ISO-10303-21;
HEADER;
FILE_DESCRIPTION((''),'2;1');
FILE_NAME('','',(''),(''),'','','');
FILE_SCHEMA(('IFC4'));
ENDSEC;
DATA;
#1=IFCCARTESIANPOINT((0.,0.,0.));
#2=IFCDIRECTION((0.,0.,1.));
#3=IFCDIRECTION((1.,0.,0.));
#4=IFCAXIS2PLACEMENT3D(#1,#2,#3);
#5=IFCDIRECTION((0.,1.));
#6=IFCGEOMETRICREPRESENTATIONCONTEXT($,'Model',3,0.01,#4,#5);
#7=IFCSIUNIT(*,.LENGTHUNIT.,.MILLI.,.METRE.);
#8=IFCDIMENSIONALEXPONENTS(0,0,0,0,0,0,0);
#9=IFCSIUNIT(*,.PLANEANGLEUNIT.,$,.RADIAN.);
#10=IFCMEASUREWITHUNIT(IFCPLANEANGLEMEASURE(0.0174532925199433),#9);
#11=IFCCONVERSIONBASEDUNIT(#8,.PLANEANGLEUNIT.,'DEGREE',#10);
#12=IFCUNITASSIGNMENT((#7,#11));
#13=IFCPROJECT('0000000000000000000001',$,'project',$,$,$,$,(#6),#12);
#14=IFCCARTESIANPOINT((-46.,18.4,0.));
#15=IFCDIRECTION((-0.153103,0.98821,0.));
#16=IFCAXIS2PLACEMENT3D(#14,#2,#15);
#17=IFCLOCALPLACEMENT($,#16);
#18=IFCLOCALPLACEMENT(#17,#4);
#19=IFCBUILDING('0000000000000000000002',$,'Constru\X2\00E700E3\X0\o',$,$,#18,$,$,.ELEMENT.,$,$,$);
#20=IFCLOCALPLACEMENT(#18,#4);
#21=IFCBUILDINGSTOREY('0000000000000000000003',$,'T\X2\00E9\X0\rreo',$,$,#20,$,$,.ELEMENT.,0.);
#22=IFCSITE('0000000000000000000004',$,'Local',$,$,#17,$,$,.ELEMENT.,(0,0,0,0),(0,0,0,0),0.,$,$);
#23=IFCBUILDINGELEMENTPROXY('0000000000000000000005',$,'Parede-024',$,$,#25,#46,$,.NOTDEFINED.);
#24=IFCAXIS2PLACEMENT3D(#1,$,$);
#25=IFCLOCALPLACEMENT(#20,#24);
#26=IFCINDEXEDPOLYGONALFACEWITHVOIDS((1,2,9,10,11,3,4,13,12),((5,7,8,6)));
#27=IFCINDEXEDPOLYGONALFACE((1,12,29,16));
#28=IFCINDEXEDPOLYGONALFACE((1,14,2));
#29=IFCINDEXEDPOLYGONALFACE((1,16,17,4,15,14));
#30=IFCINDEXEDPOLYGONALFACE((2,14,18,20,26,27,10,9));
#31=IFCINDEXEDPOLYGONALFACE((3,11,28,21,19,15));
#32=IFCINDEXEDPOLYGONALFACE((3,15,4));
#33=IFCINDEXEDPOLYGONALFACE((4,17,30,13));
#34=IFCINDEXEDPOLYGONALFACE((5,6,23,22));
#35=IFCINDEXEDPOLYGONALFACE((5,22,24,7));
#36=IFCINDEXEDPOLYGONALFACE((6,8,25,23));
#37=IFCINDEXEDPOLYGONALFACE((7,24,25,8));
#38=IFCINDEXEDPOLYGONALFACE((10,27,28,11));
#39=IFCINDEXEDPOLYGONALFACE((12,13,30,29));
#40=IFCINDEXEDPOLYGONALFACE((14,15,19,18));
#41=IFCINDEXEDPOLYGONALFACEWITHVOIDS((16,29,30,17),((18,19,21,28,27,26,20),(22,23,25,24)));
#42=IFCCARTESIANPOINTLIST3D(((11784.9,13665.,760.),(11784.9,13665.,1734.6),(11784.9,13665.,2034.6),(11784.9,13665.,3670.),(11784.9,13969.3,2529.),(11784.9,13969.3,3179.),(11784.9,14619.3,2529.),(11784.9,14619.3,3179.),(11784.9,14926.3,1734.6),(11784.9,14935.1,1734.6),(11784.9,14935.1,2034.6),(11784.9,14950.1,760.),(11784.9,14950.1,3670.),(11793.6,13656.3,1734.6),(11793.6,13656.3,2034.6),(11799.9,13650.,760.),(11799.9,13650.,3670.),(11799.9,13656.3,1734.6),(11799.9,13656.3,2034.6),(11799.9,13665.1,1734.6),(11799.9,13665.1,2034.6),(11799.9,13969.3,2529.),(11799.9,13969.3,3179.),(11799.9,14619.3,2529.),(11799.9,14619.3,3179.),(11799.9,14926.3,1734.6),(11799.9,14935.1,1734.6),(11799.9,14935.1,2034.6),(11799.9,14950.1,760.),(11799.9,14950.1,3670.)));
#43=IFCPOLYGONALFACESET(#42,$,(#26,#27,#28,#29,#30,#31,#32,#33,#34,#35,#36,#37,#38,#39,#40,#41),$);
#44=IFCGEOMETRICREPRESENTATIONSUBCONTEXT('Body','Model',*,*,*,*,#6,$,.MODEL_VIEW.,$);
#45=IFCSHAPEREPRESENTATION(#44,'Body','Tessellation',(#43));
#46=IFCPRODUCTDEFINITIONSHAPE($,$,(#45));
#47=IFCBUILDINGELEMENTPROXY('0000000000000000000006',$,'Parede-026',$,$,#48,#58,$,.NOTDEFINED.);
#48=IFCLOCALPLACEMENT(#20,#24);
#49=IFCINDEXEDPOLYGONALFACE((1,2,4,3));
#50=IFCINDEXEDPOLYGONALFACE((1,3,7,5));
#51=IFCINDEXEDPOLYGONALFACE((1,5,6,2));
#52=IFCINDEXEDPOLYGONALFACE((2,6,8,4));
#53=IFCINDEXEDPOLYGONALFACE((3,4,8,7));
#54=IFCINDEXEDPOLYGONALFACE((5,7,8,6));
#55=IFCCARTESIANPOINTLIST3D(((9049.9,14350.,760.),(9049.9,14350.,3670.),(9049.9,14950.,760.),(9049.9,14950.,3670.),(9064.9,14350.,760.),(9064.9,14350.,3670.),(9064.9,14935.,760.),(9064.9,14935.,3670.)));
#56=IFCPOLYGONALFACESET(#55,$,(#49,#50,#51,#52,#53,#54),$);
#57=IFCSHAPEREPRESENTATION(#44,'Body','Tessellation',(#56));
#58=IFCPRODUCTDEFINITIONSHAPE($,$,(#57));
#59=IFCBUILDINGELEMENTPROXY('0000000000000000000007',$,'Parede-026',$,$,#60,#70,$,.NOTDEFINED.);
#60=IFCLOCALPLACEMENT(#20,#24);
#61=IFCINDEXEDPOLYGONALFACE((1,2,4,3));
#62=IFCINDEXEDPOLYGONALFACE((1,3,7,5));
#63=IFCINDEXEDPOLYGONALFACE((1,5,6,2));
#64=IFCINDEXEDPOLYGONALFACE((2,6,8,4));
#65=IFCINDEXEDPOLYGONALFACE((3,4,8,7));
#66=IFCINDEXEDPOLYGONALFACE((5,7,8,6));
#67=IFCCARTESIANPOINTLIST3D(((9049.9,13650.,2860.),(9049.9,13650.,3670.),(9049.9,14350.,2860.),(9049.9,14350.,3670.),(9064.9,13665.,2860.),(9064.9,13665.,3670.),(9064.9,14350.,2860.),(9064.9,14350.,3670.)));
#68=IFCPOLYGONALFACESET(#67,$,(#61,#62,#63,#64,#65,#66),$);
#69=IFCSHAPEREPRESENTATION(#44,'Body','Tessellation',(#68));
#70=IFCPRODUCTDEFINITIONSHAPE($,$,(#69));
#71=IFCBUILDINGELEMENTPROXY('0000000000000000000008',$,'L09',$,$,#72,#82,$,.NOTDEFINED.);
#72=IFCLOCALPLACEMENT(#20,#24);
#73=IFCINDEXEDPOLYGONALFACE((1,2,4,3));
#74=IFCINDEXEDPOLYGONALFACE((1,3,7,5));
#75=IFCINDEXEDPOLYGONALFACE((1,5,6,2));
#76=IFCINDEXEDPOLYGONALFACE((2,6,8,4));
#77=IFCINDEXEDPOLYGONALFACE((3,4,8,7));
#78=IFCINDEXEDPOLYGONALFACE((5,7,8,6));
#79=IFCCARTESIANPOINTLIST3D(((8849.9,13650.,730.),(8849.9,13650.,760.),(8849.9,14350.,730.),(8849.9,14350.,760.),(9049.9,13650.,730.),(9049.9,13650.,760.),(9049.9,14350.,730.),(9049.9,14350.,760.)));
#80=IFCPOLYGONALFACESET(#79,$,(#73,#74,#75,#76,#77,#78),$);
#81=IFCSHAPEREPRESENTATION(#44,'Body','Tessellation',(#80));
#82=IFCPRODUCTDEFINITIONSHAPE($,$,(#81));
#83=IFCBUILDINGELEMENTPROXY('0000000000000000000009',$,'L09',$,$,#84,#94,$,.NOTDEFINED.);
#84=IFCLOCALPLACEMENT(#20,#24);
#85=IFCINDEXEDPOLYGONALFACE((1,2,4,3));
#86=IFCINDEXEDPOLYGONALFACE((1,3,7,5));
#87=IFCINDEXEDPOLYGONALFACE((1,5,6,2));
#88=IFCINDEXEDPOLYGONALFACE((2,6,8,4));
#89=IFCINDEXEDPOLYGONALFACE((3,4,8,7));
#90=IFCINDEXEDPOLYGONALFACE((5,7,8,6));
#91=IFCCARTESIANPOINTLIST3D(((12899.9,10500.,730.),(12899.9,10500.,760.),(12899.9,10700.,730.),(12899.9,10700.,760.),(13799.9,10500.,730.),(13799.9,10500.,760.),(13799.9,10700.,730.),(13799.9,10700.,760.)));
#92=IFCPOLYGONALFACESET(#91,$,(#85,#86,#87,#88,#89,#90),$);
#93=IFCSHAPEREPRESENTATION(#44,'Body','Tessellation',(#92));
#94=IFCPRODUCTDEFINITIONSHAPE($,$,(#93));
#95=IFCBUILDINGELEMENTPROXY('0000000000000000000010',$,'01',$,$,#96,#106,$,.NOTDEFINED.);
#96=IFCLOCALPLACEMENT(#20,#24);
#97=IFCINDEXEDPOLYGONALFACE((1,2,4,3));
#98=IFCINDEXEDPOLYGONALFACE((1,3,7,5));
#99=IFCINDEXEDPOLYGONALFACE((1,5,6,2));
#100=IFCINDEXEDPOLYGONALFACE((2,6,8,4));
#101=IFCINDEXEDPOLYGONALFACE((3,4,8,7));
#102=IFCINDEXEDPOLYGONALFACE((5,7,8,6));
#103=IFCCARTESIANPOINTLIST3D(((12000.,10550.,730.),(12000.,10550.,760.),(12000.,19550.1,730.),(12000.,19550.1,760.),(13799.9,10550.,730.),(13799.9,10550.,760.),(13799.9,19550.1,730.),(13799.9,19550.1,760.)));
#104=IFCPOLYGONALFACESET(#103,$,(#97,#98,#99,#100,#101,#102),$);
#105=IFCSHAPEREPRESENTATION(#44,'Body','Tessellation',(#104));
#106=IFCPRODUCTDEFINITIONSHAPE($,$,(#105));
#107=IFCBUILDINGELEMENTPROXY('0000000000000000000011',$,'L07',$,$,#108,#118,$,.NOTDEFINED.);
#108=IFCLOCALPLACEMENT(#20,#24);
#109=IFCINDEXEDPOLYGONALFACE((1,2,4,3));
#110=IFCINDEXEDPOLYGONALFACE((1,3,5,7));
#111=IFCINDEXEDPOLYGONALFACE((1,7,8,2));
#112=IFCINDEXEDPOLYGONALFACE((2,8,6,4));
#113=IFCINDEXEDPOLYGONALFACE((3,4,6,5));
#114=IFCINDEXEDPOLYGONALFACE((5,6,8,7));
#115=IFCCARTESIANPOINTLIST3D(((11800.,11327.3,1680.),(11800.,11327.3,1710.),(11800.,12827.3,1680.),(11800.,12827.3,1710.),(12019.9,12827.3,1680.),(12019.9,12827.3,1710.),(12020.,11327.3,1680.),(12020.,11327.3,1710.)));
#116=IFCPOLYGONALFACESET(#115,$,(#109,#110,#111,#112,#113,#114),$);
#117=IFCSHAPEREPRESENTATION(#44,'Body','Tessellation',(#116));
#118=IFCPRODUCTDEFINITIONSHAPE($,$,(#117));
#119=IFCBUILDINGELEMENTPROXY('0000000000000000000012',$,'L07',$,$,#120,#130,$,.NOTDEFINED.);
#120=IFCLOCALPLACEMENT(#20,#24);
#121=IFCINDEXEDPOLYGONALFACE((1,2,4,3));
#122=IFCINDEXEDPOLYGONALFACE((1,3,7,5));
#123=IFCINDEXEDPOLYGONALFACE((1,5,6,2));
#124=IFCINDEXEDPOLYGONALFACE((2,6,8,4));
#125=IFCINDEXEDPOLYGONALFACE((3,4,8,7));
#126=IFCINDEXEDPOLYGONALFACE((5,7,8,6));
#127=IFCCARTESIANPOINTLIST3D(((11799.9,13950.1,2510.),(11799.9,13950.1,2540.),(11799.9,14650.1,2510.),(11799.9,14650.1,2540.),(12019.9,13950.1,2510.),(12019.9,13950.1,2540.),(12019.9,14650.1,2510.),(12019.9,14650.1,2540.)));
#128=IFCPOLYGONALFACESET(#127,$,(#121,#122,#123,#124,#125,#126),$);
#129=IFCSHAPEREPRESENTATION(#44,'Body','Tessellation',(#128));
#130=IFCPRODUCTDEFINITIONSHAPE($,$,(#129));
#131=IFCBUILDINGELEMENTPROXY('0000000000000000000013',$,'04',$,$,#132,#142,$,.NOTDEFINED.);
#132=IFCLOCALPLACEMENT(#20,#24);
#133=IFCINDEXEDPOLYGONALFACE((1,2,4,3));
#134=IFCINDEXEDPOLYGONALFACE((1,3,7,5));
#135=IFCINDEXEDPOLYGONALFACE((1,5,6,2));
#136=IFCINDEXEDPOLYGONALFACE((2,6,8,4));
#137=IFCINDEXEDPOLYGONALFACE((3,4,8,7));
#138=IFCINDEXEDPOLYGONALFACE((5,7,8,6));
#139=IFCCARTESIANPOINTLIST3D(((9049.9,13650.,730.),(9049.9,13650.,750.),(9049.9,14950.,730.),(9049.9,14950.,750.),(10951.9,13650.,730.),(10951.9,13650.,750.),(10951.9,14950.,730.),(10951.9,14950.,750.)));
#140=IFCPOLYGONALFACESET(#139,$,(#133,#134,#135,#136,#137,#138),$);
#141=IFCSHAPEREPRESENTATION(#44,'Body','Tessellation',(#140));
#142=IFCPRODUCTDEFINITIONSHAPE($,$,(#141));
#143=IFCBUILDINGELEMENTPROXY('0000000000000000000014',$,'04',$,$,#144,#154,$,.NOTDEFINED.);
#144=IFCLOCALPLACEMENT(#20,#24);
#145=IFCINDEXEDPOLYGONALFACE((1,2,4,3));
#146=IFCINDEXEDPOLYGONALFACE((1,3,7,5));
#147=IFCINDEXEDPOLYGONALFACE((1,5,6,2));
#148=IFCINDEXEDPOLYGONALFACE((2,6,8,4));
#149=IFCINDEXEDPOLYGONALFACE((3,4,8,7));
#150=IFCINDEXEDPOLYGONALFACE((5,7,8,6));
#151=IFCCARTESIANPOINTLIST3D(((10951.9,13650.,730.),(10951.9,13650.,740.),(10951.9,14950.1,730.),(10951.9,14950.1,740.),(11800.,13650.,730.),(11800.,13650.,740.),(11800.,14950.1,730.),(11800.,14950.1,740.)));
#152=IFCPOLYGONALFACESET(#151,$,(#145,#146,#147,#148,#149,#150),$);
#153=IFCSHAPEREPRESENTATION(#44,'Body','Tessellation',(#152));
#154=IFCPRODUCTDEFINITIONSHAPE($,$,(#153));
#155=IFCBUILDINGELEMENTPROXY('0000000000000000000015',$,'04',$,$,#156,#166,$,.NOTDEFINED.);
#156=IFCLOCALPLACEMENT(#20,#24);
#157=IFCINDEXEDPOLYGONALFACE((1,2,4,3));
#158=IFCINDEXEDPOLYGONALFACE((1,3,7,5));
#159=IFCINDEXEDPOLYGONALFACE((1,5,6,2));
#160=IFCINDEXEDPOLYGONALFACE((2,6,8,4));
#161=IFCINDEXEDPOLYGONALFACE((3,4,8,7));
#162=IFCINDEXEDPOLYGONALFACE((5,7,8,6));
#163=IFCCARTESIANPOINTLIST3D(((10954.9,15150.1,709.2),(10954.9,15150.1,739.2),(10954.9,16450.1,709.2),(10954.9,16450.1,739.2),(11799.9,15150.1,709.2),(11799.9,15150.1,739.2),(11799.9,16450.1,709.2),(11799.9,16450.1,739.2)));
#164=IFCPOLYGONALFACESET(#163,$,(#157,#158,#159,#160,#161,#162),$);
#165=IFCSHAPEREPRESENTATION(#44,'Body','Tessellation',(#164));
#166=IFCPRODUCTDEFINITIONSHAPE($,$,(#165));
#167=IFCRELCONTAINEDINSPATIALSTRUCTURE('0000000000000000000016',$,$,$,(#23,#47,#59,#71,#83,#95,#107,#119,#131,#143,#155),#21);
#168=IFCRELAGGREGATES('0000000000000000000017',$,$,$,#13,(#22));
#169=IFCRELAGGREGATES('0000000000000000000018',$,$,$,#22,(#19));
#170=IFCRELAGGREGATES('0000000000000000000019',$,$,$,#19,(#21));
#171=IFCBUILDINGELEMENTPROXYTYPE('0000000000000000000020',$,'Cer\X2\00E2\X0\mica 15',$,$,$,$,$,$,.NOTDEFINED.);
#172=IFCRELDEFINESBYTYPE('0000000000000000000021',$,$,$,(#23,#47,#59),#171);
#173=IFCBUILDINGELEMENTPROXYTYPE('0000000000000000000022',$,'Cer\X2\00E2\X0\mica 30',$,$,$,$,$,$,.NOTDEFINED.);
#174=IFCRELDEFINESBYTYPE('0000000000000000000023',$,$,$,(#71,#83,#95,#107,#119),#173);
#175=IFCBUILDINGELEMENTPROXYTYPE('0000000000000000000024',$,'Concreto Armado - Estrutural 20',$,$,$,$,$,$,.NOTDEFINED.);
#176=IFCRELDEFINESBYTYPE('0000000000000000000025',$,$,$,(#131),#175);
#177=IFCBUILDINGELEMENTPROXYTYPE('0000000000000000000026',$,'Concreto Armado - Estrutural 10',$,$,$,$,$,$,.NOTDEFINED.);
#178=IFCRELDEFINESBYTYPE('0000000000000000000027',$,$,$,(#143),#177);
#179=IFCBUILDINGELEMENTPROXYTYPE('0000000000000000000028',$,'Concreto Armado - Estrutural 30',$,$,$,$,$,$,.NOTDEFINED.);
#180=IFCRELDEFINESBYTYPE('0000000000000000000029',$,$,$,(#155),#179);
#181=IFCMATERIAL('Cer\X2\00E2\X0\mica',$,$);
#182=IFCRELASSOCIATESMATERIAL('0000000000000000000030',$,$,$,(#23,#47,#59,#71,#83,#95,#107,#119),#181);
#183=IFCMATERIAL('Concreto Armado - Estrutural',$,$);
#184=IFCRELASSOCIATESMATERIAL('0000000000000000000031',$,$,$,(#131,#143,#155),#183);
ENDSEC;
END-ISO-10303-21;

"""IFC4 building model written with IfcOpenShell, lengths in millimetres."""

from ifc_helpers import new_model, entity, si_unit, converted_unit, direction, frame, origin_with_axes, origin_2d_with_axis, place, context, subcontext, project, spatial, line, indexed_curve, rectangle, outline, extrude, material, type_object, element, save


model = new_model("IFC4")

# Units and contexts
model_context = context("Model", 3, precision=0.01, world=origin_with_axes(), true_north=direction((0.0, 1.0)))
body_context = subcontext(model_context, "Body", "Model", "MODEL_VIEW")
ifc_project = project(units=[si_unit("LENGTHUNIT", "METRE", prefix="MILLI"), converted_unit("PLANEANGLEUNIT", "DEGREE", entity("IfcPlaneAngleMeasure", 0.0174532925199433), si_unit("PLANEANGLEUNIT", "RADIAN"), dimensions=[0, 0, 0, 0, 0, 0, 0])], contexts=[model_context])

# Site, building, storey
site_placement = place(None, frame((-46.0, 18.4, 0.0), z_axis=(0.0, 0.0, 1.0), x_axis=(-0.153103, 0.98821, 0.0)))
site = spatial("IfcSite", under=ifc_project, at=site_placement, Name="Local", CompositionType="ELEMENT", RefLatitude=(0, 0, 0, 0), RefLongitude=(0, 0, 0, 0), RefElevation=0.0)
building_placement = place(site_placement, origin_with_axes())
building = spatial("IfcBuilding", under=site, at=building_placement, Name="Construção", CompositionType="ELEMENT")
storey_placement = place(building_placement, origin_with_axes())
storey = spatial("IfcBuildingStorey", under=building, at=storey_placement, Name="Térreo", CompositionType="ELEMENT", Elevation=0.0)

# Shared definitions
ifc_material_1 = material(Name="Concreto Armado - Estrutural")

# Shared definitions
ifc_material_2 = material(Name="Cerâmica")
building_element_proxy_type_1 = type_object("IfcBuildingElementProxyType", Name="Cerâmica 15", PredefinedType="NOTDEFINED")

# Building element proxy, openings
proxy_1_placement = place(storey_placement, frame((11799.9, 13650.0, 760.0), z_axis=(0.0, 0.0, 1.0), x_axis=(0.0, 1.0, 0.0)))
proxy_1 = element("IfcBuildingElementProxy", 1, at=proxy_1_placement, inside=storey, type_object=building_element_proxy_type_1, material=ifc_material_2, Name="Parede-024", PredefinedType="NOTDEFINED", context=body_context, shape_type="SweptSolid", body=[
    extrude(outline(indexed_curve([(0.0, 0.0), (1300.0, 0.0), (1300.0, 15.0), (15.0, 15.0)], segments=[line(1, 2, 3, 4, 1)])), origin_with_axes(), (0.0, 0.0, 1.0), 2910.0),
])
opening_1_placement = place(proxy_1_placement, frame((-13650.0, 11799.9, -760.0), z_axis=(0.0, 0.0, 1.0), x_axis=(0.0, -1.0, 0.0)))
element("IfcOpeningElement", 2, at=opening_1_placement, cuts=proxy_1, PredefinedType="OPENING", context=body_context, shape_type="SweptSolid", body=[
    extrude(rectangle(XDim=650.0, YDim=650.0, at=origin_2d_with_axis()), frame((11814.9, 14294.3, 2854.0), z_axis=(1.0, 0.0, 0.0), x_axis=(0.0, 1.0, 0.0)), (0.0, 0.0, -1.0), 45.0),
])
opening_2_placement = place(proxy_1_placement, frame((-13650.0, 11799.9, -760.0), z_axis=(0.0, 0.0, 1.0), x_axis=(0.0, -1.0, 0.0)))
element("IfcOpeningElement", 3, at=opening_2_placement, cuts=proxy_1, PredefinedType="OPENING", context=body_context, shape_type="SweptSolid", body=[
    extrude(rectangle(XDim=1270.0, YDim=300.0, at=origin_2d_with_axis()), frame((11814.9, 14300.1, 1884.6), z_axis=(1.0, 0.0, 0.0), x_axis=(0.0, 1.0, 0.0)), (0.0, 0.0, -1.0), 45.0),
])
opening_3_placement = place(proxy_1_placement, frame((-13650.0, 11799.9, -760.0), z_axis=(0.0, 0.0, 1.0), x_axis=(0.0, -1.0, 0.0)))
element("IfcOpeningElement", 4, at=opening_3_placement, cuts=proxy_1, PredefinedType="OPENING", context=body_context, shape_type="SweptSolid", body=[
    extrude(outline(indexed_curve([(-639.4, -150.0), (630.6, -150.0), (639.4, 150.0), (-639.4, 150.0)], segments=[line(1, 2, 3, 4, 1)])), frame((11814.9, 14295.7, 1884.6), z_axis=(1.0, 0.0, 0.0), x_axis=(0.0, 1.0, 0.0)), (0.0, 0.0, -1.0), 45.0),
])

# Building element proxies
proxy_2_placement = place(storey_placement, frame((9049.9, 14950.0, 760.0), z_axis=(0.0, 0.0, 1.0), x_axis=(0.000002, -1.0, 0.0)))
element("IfcBuildingElementProxy", 5, at=proxy_2_placement, inside=storey, type_object=building_element_proxy_type_1, material=ifc_material_2, Name="Parede-026", PredefinedType="NOTDEFINED", context=body_context, shape_type="SweptSolid", body=[
    extrude(outline(indexed_curve([(0.0, 0.0), (600.0, 0.0), (600.0, 15.0), (15.0, 15.0)], segments=[line(1, 2, 3, 4, 1)])), origin_with_axes(), (0.0, 0.0, 1.0), 2910.0),
])
proxy_3_placement = place(storey_placement, frame((9049.9, 14350.0, 2860.0), z_axis=(0.0, 0.0, 1.0), x_axis=(0.000002, -1.0, 0.0)))
element("IfcBuildingElementProxy", 6, at=proxy_3_placement, inside=storey, type_object=building_element_proxy_type_1, material=ifc_material_2, Name="Parede-026", PredefinedType="NOTDEFINED", context=body_context, shape_type="SweptSolid", body=[
    extrude(outline(indexed_curve([(0.0, 0.0), (700.0, 0.0), (685.0, 15.0), (0.0, 15.0)], segments=[line(1, 2, 3, 4, 1)])), origin_with_axes(), (0.0, 0.0, 1.0), 810.0),
])
building_element_proxy_type_2 = type_object("IfcBuildingElementProxyType", Name="Cerâmica 30", PredefinedType="NOTDEFINED")
proxy_4_placement = place(storey_placement, frame((8849.9, 13650.0, 760.0), z_axis=(0.0, 0.0, 1.0), x_axis=(1.0, 0.0, 0.0)))
element("IfcBuildingElementProxy", 7, at=proxy_4_placement, inside=storey, type_object=building_element_proxy_type_2, material=ifc_material_2, Name="L09", PredefinedType="NOTDEFINED", context=body_context, shape_type="SweptSolid", body=[
    extrude(outline(indexed_curve([(0.0, 0.0), (200.0, 0.0), (200.0, 700.0), (0.0, 700.0)], segments=[line(1, 2, 3, 4, 1)])), frame((0.0, 0.0, -30.0), z_axis=(0.0, 0.0, 1.0), x_axis=(1.0, 0.0, 0.0)), (0.0, 0.0, 1.0), 30.0),
])
proxy_5_placement = place(storey_placement, frame((12899.9, 10500.0, 760.0), z_axis=(0.0, 0.0, 1.0), x_axis=(1.0, 0.0, 0.0)))
element("IfcBuildingElementProxy", 8, at=proxy_5_placement, inside=storey, type_object=building_element_proxy_type_2, material=ifc_material_2, Name="L09", PredefinedType="NOTDEFINED", context=body_context, shape_type="SweptSolid", body=[
    extrude(outline(indexed_curve([(0.0, 0.0), (900.0, 0.0), (900.0, 200.0), (0.0, 200.0)], segments=[line(1, 2, 3, 4, 1)])), frame((0.0, 0.0, -30.0), z_axis=(0.0, 0.0, 1.0), x_axis=(1.0, 0.0, 0.0)), (0.0, 0.0, 1.0), 30.0),
])
proxy_6_placement = place(storey_placement, frame((12000.0, 10550.0, 760.0), z_axis=(0.0, 0.0, 1.0), x_axis=(1.0, 0.0, 0.0)))
element("IfcBuildingElementProxy", 9, at=proxy_6_placement, inside=storey, type_object=building_element_proxy_type_2, material=ifc_material_2, Name="01", PredefinedType="NOTDEFINED", context=body_context, shape_type="SweptSolid", body=[
    extrude(outline(indexed_curve([(0.0, 0.0), (1799.9, 0.0), (1799.9, 9000.1), (0.0, 9000.1)], segments=[line(1, 2, 3, 4, 1)])), frame((0.0, 0.0, -30.0), z_axis=(0.0, 0.0, 1.0), x_axis=(1.0, 0.0, 0.0)), (0.0, 0.0, 1.0), 30.0),
])
proxy_7_placement = place(storey_placement, frame((11800.0, 11327.3, 1710.0), z_axis=(0.0, 0.0, 1.0), x_axis=(1.0, 0.0, 0.0)))
element("IfcBuildingElementProxy", 10, at=proxy_7_placement, inside=storey, type_object=building_element_proxy_type_2, material=ifc_material_2, Name="L07", PredefinedType="NOTDEFINED", context=body_context, shape_type="SweptSolid", body=[
    extrude(outline(indexed_curve([(0.0, 0.0), (220.0, 0.0), (220.0, 1500.0), (0.0, 1500.0)], segments=[line(1, 2, 3, 4, 1)])), frame((0.0, 0.0, -30.0), z_axis=(0.0, 0.0, 1.0), x_axis=(1.0, 0.0, 0.0)), (0.0, 0.0, 1.0), 30.0),
])
proxy_8_placement = place(storey_placement, frame((11799.9, 13950.1, 2540.0), z_axis=(0.0, 0.0, 1.0), x_axis=(1.0, 0.0, 0.0)))
element("IfcBuildingElementProxy", 11, at=proxy_8_placement, inside=storey, type_object=building_element_proxy_type_2, material=ifc_material_2, Name="L07", PredefinedType="NOTDEFINED", context=body_context, shape_type="SweptSolid", body=[
    extrude(outline(indexed_curve([(0.0, 0.0), (220.0, 0.0), (220.0, 700.0), (0.0, 700.0)], segments=[line(1, 2, 3, 4, 1)])), frame((0.0, 0.0, -30.0), z_axis=(0.0, 0.0, 1.0), x_axis=(1.0, 0.0, 0.0)), (0.0, 0.0, 1.0), 30.0),
])
building_element_proxy_type_3 = type_object("IfcBuildingElementProxyType", Name="Concreto Armado - Estrutural 20", PredefinedType="NOTDEFINED")
proxy_9_placement = place(storey_placement, frame((9049.9, 13650.0, 750.0), z_axis=(0.0, 0.0, 1.0), x_axis=(1.0, 0.0, 0.0)))
element("IfcBuildingElementProxy", 12, at=proxy_9_placement, inside=storey, type_object=building_element_proxy_type_3, material=ifc_material_1, Name="04", PredefinedType="NOTDEFINED", context=body_context, shape_type="SweptSolid", body=[
    extrude(outline(indexed_curve([(0.0, 0.0), (1901.9, 0.0), (1901.9, 1300.0), (0.0, 1300.0)], segments=[line(1, 2, 3, 4, 1)])), frame((0.0, 0.0, -20.0), z_axis=(0.0, 0.0, 1.0), x_axis=(1.0, 0.0, 0.0)), (0.0, 0.0, 1.0), 20.0),
])
building_element_proxy_type_4 = type_object("IfcBuildingElementProxyType", Name="Concreto Armado - Estrutural 10", PredefinedType="NOTDEFINED")
proxy_10_placement = place(storey_placement, frame((10951.9, 13650.0, 740.0), z_axis=(0.0, 0.0, 1.0), x_axis=(1.0, 0.0, 0.0)))
element("IfcBuildingElementProxy", 13, at=proxy_10_placement, inside=storey, type_object=building_element_proxy_type_4, material=ifc_material_1, Name="04", PredefinedType="NOTDEFINED", context=body_context, shape_type="SweptSolid", body=[
    extrude(outline(indexed_curve([(0.0, 0.0), (848.1, 0.0), (848.1, 1300.0), (0.0, 1300.0)], segments=[line(1, 2, 3, 4, 1)])), frame((0.0, 0.0, -10.0), z_axis=(0.0, 0.0, 1.0), x_axis=(1.0, 0.0, 0.0)), (0.0, 0.0, 1.0), 10.0),
])
building_element_proxy_type_5 = type_object("IfcBuildingElementProxyType", Name="Concreto Armado - Estrutural 30", PredefinedType="NOTDEFINED")
proxy_11_placement = place(storey_placement, frame((10954.9, 15150.1, 739.2), z_axis=(0.0, 0.0, 1.0), x_axis=(1.0, 0.0, 0.0)))
element("IfcBuildingElementProxy", 14, at=proxy_11_placement, inside=storey, type_object=building_element_proxy_type_5, material=ifc_material_1, Name="04", PredefinedType="NOTDEFINED", context=body_context, shape_type="SweptSolid", body=[
    extrude(outline(indexed_curve([(0.0, 0.0), (845.0, 0.0), (845.0, 1300.0), (0.0, 1300.0)], segments=[line(1, 2, 3, 4, 1)])), frame((0.0, 0.0, -30.0), z_axis=(0.0, 0.0, 1.0), x_axis=(1.0, 0.0, 0.0)), (0.0, 0.0, 1.0), 30.0),
])

save(model, "model.ifc")
